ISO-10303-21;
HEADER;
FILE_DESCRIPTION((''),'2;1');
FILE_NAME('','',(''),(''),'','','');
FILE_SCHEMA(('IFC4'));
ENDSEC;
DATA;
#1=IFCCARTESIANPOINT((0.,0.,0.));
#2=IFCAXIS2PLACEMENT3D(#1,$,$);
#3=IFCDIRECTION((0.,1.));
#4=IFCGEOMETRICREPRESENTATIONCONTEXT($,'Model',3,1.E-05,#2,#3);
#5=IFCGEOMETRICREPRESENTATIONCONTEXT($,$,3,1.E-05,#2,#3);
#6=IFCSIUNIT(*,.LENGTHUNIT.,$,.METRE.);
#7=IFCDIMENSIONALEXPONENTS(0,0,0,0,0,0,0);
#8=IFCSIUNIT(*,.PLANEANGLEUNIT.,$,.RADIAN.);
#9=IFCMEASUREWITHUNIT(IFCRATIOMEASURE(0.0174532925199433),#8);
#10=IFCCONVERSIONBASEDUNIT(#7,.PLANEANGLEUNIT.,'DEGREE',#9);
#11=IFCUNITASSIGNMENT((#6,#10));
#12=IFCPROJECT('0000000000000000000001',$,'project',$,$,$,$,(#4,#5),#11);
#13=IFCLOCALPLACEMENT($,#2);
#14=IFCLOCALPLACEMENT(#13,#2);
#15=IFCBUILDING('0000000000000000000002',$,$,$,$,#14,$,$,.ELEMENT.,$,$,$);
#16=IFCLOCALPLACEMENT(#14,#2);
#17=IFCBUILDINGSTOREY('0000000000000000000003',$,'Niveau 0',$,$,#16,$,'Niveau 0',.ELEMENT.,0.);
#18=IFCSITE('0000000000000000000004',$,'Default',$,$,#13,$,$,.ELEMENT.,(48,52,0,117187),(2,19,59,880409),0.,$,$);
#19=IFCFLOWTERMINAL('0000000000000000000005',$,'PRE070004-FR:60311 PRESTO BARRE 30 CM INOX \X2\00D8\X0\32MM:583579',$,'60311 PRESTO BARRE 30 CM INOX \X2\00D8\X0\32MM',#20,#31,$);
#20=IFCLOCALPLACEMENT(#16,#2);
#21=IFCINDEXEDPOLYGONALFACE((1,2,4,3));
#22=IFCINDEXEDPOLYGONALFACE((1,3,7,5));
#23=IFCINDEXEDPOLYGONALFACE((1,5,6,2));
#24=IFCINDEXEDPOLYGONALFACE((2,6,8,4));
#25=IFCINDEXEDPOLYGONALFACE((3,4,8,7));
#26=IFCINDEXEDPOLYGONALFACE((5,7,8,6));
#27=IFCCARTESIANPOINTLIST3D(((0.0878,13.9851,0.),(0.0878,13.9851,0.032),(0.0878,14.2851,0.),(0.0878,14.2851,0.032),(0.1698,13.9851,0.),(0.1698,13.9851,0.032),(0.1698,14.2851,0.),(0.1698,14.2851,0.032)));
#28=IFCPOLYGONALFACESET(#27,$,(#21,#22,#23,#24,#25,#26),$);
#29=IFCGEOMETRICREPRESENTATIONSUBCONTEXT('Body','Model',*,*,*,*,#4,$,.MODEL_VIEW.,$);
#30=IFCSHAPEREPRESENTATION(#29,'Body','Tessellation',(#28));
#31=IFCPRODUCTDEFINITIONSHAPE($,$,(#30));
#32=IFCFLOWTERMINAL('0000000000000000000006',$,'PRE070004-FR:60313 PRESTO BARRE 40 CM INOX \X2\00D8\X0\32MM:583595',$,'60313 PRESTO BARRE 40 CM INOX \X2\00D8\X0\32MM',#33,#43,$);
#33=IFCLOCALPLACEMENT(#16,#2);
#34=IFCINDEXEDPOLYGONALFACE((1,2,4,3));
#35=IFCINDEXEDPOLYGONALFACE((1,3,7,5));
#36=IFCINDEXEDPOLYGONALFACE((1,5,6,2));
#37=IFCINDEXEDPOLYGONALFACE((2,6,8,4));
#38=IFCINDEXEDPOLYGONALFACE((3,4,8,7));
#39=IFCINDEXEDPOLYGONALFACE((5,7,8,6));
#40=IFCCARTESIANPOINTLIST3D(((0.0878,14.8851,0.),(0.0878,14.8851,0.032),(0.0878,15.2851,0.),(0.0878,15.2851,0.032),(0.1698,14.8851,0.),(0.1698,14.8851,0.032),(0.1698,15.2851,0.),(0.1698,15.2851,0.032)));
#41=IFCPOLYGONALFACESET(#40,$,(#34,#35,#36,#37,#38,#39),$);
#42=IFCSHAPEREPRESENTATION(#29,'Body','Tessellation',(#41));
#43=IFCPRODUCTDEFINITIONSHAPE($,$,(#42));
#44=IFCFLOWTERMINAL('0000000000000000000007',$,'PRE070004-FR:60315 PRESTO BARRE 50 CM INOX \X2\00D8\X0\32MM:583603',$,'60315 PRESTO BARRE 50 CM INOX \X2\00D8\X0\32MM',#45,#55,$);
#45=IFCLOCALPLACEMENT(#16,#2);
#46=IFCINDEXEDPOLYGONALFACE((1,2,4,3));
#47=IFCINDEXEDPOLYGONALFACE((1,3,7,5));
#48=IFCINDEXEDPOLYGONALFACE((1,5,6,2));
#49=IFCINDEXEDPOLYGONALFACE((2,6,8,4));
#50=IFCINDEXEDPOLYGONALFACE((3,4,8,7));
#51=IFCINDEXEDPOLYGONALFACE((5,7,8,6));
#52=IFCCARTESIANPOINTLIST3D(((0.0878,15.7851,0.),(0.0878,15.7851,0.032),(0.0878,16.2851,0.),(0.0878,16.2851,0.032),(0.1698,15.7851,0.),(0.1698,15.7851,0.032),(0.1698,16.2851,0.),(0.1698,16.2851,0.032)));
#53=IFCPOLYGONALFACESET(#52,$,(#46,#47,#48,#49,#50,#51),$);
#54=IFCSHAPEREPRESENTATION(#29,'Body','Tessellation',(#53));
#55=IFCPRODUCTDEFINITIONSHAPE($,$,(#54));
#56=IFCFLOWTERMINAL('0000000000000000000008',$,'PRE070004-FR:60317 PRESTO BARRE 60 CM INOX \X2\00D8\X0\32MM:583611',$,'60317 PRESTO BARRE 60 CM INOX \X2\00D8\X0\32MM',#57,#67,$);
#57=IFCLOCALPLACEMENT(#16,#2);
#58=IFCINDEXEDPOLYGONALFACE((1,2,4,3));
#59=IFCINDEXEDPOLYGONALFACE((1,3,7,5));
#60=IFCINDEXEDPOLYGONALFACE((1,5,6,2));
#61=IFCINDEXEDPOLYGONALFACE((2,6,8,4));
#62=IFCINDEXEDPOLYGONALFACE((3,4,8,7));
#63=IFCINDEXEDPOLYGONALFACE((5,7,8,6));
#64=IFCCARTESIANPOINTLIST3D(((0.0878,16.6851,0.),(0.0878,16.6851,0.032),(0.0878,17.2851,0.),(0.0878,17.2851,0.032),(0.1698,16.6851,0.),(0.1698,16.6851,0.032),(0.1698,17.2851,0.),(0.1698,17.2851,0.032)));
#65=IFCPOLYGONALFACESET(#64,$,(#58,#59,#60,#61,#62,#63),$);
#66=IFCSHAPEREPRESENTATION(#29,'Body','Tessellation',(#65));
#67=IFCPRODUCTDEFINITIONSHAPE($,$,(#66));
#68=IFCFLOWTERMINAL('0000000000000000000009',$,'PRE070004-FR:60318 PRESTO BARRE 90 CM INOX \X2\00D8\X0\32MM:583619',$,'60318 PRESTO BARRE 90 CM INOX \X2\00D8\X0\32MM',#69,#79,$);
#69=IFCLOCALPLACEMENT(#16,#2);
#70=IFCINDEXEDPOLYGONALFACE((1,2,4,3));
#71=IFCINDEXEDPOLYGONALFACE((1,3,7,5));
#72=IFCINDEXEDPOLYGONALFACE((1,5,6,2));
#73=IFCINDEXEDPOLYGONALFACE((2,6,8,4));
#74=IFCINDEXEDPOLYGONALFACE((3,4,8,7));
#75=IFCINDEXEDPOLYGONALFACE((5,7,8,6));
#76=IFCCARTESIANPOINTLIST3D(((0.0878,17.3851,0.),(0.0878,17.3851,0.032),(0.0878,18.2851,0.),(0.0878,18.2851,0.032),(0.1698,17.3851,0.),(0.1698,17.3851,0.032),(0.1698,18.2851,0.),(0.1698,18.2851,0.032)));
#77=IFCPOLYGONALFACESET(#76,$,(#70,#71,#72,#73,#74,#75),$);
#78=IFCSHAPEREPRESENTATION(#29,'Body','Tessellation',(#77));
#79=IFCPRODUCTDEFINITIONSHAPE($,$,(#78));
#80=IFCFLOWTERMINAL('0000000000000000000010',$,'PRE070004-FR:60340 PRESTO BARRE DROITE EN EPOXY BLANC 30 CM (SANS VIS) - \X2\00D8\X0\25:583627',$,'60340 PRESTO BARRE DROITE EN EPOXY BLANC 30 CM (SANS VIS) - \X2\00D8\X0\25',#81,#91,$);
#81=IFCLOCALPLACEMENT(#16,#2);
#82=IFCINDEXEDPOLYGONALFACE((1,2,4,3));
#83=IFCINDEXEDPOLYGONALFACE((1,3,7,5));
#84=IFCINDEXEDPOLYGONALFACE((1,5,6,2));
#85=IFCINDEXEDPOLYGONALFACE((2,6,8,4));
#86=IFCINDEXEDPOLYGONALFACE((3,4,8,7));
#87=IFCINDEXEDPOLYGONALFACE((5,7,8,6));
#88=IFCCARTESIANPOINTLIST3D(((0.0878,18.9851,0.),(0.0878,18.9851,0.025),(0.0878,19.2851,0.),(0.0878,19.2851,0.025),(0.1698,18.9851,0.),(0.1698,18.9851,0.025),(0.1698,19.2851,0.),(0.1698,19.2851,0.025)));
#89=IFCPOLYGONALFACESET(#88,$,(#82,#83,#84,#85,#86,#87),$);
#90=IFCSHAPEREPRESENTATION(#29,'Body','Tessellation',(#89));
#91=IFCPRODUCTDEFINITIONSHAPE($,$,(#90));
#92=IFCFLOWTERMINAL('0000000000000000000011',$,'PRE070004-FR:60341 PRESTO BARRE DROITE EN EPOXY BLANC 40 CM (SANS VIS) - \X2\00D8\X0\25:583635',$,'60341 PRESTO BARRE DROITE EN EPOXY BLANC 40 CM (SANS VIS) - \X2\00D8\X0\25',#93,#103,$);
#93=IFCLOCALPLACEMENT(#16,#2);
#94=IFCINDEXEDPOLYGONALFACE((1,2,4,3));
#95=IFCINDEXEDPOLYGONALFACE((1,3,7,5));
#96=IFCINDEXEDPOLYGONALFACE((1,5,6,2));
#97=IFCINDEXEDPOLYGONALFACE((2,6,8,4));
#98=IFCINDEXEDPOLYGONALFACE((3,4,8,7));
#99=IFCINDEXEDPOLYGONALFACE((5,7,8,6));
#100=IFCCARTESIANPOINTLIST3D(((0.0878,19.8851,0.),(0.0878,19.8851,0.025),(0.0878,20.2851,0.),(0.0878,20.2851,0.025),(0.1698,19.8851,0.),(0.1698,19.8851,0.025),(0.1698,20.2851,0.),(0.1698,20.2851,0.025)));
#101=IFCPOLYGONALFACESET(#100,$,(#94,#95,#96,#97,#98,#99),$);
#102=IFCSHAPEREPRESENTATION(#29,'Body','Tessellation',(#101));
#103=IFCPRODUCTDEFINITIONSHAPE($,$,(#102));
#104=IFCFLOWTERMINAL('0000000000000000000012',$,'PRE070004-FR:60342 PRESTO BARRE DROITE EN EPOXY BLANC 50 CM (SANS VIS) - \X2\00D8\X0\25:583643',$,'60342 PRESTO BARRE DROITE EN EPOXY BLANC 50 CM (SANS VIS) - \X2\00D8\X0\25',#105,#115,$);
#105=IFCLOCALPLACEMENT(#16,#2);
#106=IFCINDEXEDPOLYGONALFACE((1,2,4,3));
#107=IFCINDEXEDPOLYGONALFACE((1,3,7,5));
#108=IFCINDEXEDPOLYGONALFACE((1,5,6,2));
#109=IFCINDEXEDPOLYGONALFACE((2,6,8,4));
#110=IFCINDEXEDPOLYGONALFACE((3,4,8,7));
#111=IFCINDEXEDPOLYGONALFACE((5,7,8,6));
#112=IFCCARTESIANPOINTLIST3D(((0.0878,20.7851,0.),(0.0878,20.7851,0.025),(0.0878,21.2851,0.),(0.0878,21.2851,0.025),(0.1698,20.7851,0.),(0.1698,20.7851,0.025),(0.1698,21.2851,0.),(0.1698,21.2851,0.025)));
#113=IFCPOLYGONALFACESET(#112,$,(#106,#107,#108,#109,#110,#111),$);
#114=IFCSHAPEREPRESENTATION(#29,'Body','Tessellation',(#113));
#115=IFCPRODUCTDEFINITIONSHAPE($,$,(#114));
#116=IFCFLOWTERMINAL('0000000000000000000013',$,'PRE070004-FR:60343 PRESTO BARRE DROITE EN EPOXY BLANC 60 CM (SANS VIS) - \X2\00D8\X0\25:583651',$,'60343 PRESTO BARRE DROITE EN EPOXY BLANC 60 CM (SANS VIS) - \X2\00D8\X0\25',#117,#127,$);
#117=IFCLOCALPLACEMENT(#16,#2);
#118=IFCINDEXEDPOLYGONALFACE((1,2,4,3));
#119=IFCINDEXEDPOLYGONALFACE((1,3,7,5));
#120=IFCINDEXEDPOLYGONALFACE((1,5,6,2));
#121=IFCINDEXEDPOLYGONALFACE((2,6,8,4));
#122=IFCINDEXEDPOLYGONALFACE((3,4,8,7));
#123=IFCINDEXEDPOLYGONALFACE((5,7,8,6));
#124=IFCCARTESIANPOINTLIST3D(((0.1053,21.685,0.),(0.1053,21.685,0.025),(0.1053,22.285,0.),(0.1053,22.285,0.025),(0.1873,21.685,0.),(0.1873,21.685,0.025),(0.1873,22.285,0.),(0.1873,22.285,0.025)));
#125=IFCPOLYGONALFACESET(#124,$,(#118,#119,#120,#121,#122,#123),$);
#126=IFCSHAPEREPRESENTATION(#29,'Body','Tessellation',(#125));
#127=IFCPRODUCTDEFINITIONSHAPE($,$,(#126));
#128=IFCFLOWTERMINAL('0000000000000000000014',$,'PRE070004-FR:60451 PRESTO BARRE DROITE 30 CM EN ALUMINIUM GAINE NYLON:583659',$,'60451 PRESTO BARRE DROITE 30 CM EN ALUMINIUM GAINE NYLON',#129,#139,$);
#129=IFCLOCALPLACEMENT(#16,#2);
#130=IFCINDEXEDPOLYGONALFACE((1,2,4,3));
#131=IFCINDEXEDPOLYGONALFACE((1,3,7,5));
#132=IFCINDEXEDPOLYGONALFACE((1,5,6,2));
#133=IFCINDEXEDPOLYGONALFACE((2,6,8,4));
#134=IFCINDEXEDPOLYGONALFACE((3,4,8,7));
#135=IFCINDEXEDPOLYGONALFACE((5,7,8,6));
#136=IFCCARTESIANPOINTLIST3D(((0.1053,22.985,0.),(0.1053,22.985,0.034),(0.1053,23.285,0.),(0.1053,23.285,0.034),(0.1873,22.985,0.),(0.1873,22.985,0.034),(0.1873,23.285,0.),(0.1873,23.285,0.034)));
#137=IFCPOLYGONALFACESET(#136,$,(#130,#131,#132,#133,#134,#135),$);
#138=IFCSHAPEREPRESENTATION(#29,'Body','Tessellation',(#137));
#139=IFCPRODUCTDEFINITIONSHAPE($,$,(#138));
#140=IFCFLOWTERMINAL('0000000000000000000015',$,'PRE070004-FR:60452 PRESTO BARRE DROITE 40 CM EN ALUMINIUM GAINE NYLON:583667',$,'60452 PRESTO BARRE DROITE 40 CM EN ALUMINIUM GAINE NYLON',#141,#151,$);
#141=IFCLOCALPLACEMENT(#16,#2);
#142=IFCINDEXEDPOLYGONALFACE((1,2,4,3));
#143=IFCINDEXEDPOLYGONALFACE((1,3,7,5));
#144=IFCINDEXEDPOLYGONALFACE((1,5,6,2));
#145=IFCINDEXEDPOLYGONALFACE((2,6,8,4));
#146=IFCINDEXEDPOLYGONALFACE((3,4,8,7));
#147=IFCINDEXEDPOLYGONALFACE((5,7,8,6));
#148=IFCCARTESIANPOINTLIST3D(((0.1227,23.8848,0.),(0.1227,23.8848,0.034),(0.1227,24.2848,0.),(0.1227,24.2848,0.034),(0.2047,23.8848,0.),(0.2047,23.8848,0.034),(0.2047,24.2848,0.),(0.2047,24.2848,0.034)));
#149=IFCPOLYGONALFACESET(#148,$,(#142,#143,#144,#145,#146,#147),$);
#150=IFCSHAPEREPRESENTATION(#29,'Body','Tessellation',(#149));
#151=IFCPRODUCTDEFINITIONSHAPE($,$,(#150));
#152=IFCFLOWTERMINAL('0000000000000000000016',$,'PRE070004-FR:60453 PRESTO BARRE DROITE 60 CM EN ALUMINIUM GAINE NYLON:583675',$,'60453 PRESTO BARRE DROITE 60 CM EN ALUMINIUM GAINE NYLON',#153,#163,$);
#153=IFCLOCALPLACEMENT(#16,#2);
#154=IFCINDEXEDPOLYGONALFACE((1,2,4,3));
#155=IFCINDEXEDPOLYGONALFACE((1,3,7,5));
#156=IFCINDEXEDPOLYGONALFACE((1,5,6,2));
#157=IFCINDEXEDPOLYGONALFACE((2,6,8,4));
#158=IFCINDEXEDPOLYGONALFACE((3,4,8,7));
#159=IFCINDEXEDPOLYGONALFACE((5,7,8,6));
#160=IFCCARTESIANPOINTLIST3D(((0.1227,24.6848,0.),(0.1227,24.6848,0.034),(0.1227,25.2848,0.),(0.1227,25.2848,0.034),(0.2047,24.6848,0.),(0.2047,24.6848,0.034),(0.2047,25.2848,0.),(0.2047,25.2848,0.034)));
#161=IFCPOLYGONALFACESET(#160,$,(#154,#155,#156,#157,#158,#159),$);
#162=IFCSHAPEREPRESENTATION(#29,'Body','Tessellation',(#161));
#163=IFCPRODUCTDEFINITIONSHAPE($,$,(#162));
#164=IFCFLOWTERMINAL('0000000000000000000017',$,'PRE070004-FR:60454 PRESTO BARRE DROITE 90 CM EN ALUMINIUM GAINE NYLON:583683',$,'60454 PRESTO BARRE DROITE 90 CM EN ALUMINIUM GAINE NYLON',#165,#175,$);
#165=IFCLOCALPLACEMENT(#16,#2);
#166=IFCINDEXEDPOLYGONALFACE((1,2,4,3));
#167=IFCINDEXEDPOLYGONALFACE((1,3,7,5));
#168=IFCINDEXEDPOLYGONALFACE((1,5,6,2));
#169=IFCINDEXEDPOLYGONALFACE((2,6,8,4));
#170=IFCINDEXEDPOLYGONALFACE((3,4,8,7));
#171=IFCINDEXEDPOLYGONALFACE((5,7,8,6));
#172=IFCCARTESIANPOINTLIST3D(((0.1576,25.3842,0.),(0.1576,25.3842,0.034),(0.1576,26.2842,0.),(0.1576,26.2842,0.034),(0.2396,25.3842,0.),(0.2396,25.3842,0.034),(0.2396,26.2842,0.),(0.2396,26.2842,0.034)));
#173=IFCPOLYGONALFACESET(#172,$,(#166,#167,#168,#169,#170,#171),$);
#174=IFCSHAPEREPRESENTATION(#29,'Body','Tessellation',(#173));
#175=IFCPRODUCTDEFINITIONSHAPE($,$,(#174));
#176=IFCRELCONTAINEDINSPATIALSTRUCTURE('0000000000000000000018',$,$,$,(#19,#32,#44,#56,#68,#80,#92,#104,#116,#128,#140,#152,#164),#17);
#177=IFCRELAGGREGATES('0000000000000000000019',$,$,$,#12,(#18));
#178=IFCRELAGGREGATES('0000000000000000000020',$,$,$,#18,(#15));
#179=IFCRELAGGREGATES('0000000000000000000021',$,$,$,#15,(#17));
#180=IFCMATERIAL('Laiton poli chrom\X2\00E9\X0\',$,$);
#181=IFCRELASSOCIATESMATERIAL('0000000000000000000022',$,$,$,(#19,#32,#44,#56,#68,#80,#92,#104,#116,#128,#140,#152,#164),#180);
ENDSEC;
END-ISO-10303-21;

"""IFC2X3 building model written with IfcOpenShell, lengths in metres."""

from ifc_helpers import new_model, entity, si_unit, converted_unit, direction, frame, origin, origin_2d_with_axis, place, context, subcontext, project, spatial, rectangle, extrude, source, transform, mapped, material, element, save


model = new_model("IFC2X3")

# Units and contexts
model_context = context("Model", 3, precision=1e-05, world=origin(), true_north=direction((0.0, 1.0)))
context_of_model = context(None, 3, precision=1e-05, world=origin(), true_north=direction((0.0, 1.0)))
body_context = subcontext(model_context, "Body", "Model", "MODEL_VIEW")
ifc_project = project(units=[si_unit("LENGTHUNIT", "METRE"), converted_unit("PLANEANGLEUNIT", "DEGREE", entity("IfcRatioMeasure", 0.0174532925199433), si_unit("PLANEANGLEUNIT", "RADIAN"), dimensions=[0, 0, 0, 0, 0, 0, 0])], contexts=[model_context, context_of_model])

# Site, building, storey
site_placement = place(None, origin())
site = spatial("IfcSite", under=ifc_project, at=site_placement, Name="Default", CompositionType="ELEMENT", RefLatitude=(48, 52, 0, 117187), RefLongitude=(2, 19, 59, 880409), RefElevation=0.0)
building_placement = place(site_placement, origin())
building = spatial("IfcBuilding", under=site, at=building_placement, CompositionType="ELEMENT")
storey_placement = place(building_placement, origin())
storey = spatial("IfcBuildingStorey", under=building, at=storey_placement, Name="Niveau 0", LongName="Niveau 0", CompositionType="ELEMENT", Elevation=0.0)

# Flow terminals
ifc_material = material(Name="Laiton poli chromé")
shared_shape_1 = source(origin(), body_context, "Body", "SweptSolid", [
    extrude(rectangle(XDim=0.082, YDim=0.3, at=origin_2d_with_axis()), frame((0.041, -0.15, 0.0), z_axis=(0.0, 0.0, 1.0), x_axis=(-1.0, 0.0, 0.0)), (0.0, 0.0, 1.0), 0.032),
])
flow_terminal_1_placement = place(storey_placement, frame((0.0878, 14.2851, 0.0)))
element("IfcFlowTerminal", 1, at=flow_terminal_1_placement, inside=storey, material=ifc_material, Name="PRE070004-FR:60311 PRESTO BARRE 30 CM INOX Ø32MM:583579", ObjectType="60311 PRESTO BARRE 30 CM INOX Ø32MM", context=body_context, shape_type="MappedRepresentation", body=[
    mapped(shared_shape_1, transform((0.0, 0.0, 0.0), scale=1.0)),
])
shared_shape_2 = source(origin(), body_context, "Body", "SweptSolid", [
    extrude(rectangle(XDim=0.082, YDim=0.4, at=origin_2d_with_axis()), frame((0.041, -0.2, 0.0), z_axis=(0.0, 0.0, 1.0), x_axis=(-1.0, 0.0, 0.0)), (0.0, 0.0, 1.0), 0.032),
])
flow_terminal_2_placement = place(storey_placement, frame((0.0878, 15.2851, 0.0)))
element("IfcFlowTerminal", 2, at=flow_terminal_2_placement, inside=storey, material=ifc_material, Name="PRE070004-FR:60313 PRESTO BARRE 40 CM INOX Ø32MM:583595", ObjectType="60313 PRESTO BARRE 40 CM INOX Ø32MM", context=body_context, shape_type="MappedRepresentation", body=[
    mapped(shared_shape_2, transform((0.0, 0.0, 0.0), scale=1.0)),
])
shared_shape_3 = source(origin(), body_context, "Body", "SweptSolid", [
    extrude(rectangle(XDim=0.082, YDim=0.5, at=origin_2d_with_axis()), frame((0.041, -0.25, 0.0), z_axis=(0.0, 0.0, 1.0), x_axis=(-1.0, 0.0, 0.0)), (0.0, 0.0, 1.0), 0.032),
])
flow_terminal_3_placement = place(storey_placement, frame((0.0878, 16.2851, 0.0)))
element("IfcFlowTerminal", 3, at=flow_terminal_3_placement, inside=storey, material=ifc_material, Name="PRE070004-FR:60315 PRESTO BARRE 50 CM INOX Ø32MM:583603", ObjectType="60315 PRESTO BARRE 50 CM INOX Ø32MM", context=body_context, shape_type="MappedRepresentation", body=[
    mapped(shared_shape_3, transform((0.0, 0.0, 0.0), scale=1.0)),
])
shared_shape_4 = source(origin(), body_context, "Body", "SweptSolid", [
    extrude(rectangle(XDim=0.082, YDim=0.6, at=origin_2d_with_axis()), frame((0.041, -0.3, 0.0), z_axis=(0.0, 0.0, 1.0), x_axis=(-1.0, 0.0, 0.0)), (0.0, 0.0, 1.0), 0.032),
])
flow_terminal_4_placement = place(storey_placement, frame((0.0878, 17.2851, 0.0)))
element("IfcFlowTerminal", 4, at=flow_terminal_4_placement, inside=storey, material=ifc_material, Name="PRE070004-FR:60317 PRESTO BARRE 60 CM INOX Ø32MM:583611", ObjectType="60317 PRESTO BARRE 60 CM INOX Ø32MM", context=body_context, shape_type="MappedRepresentation", body=[
    mapped(shared_shape_4, transform((0.0, 0.0, 0.0), scale=1.0)),
])
shared_shape_5 = source(origin(), body_context, "Body", "SweptSolid", [
    extrude(rectangle(XDim=0.082, YDim=0.9, at=origin_2d_with_axis()), frame((0.041, -0.45, 0.0), z_axis=(0.0, 0.0, 1.0), x_axis=(-1.0, 0.0, 0.0)), (0.0, 0.0, 1.0), 0.032),
])
flow_terminal_5_placement = place(storey_placement, frame((0.0878, 18.2851, 0.0)))
element("IfcFlowTerminal", 5, at=flow_terminal_5_placement, inside=storey, material=ifc_material, Name="PRE070004-FR:60318 PRESTO BARRE 90 CM INOX Ø32MM:583619", ObjectType="60318 PRESTO BARRE 90 CM INOX Ø32MM", context=body_context, shape_type="MappedRepresentation", body=[
    mapped(shared_shape_5, transform((0.0, 0.0, 0.0), scale=1.0)),
])
shared_shape_6 = source(origin(), body_context, "Body", "SweptSolid", [
    extrude(rectangle(XDim=0.082, YDim=0.3, at=origin_2d_with_axis()), frame((0.041, -0.15, 0.0), z_axis=(0.0, 0.0, 1.0), x_axis=(-1.0, 0.0, 0.0)), (0.0, 0.0, 1.0), 0.025),
])
flow_terminal_6_placement = place(storey_placement, frame((0.0878, 19.2851, 0.0)))
element("IfcFlowTerminal", 6, at=flow_terminal_6_placement, inside=storey, material=ifc_material, Name="PRE070004-FR:60340 PRESTO BARRE DROITE EN EPOXY BLANC 30 CM (SANS VIS) - Ø25:583627", ObjectType="60340 PRESTO BARRE DROITE EN EPOXY BLANC 30 CM (SANS VIS) - Ø25", context=body_context, shape_type="MappedRepresentation", body=[
    mapped(shared_shape_6, transform((0.0, 0.0, 0.0), scale=1.0)),
])
shared_shape_7 = source(origin(), body_context, "Body", "SweptSolid", [
    extrude(rectangle(XDim=0.082, YDim=0.4, at=origin_2d_with_axis()), frame((0.041, -0.2, 0.0), z_axis=(0.0, 0.0, 1.0), x_axis=(-1.0, 0.0, 0.0)), (0.0, 0.0, 1.0), 0.025),
])
flow_terminal_7_placement = place(storey_placement, frame((0.0878, 20.2851, 0.0)))
element("IfcFlowTerminal", 7, at=flow_terminal_7_placement, inside=storey, material=ifc_material, Name="PRE070004-FR:60341 PRESTO BARRE DROITE EN EPOXY BLANC 40 CM (SANS VIS) - Ø25:583635", ObjectType="60341 PRESTO BARRE DROITE EN EPOXY BLANC 40 CM (SANS VIS) - Ø25", context=body_context, shape_type="MappedRepresentation", body=[
    mapped(shared_shape_7, transform((0.0, 0.0, 0.0), scale=1.0)),
])
shared_shape_8 = source(origin(), body_context, "Body", "SweptSolid", [
    extrude(rectangle(XDim=0.082, YDim=0.5, at=origin_2d_with_axis()), frame((0.041, -0.25, 0.0), z_axis=(0.0, 0.0, 1.0), x_axis=(-1.0, 0.0, 0.0)), (0.0, 0.0, 1.0), 0.025),
])
flow_terminal_8_placement = place(storey_placement, frame((0.0878, 21.2851, 0.0)))
element("IfcFlowTerminal", 8, at=flow_terminal_8_placement, inside=storey, material=ifc_material, Name="PRE070004-FR:60342 PRESTO BARRE DROITE EN EPOXY BLANC 50 CM (SANS VIS) - Ø25:583643", ObjectType="60342 PRESTO BARRE DROITE EN EPOXY BLANC 50 CM (SANS VIS) - Ø25", context=body_context, shape_type="MappedRepresentation", body=[
    mapped(shared_shape_8, transform((0.0, 0.0, 0.0), scale=1.0)),
])
shared_shape_9 = source(origin(), body_context, "Body", "SweptSolid", [
    extrude(rectangle(XDim=0.082, YDim=0.6, at=origin_2d_with_axis()), frame((0.041, -0.3, 0.0), z_axis=(0.0, 0.0, 1.0), x_axis=(-1.0, 0.0, 0.0)), (0.0, 0.0, 1.0), 0.025),
])
flow_terminal_9_placement = place(storey_placement, frame((0.1053, 22.285, 0.0)))
element("IfcFlowTerminal", 9, at=flow_terminal_9_placement, inside=storey, material=ifc_material, Name="PRE070004-FR:60343 PRESTO BARRE DROITE EN EPOXY BLANC 60 CM (SANS VIS) - Ø25:583651", ObjectType="60343 PRESTO BARRE DROITE EN EPOXY BLANC 60 CM (SANS VIS) - Ø25", context=body_context, shape_type="MappedRepresentation", body=[
    mapped(shared_shape_9, transform((0.0, 0.0, 0.0), scale=1.0)),
])
shared_shape_10 = source(origin(), body_context, "Body", "SweptSolid", [
    extrude(rectangle(XDim=0.082, YDim=0.3, at=origin_2d_with_axis()), frame((0.041, -0.15, 0.0), z_axis=(0.0, 0.0, 1.0), x_axis=(-1.0, 0.0, 0.0)), (0.0, 0.0, 1.0), 0.034),
])
flow_terminal_10_placement = place(storey_placement, frame((0.1053, 23.285, 0.0)))
element("IfcFlowTerminal", 10, at=flow_terminal_10_placement, inside=storey, material=ifc_material, Name="PRE070004-FR:60451 PRESTO BARRE DROITE 30 CM EN ALUMINIUM GAINE NYLON:583659", ObjectType="60451 PRESTO BARRE DROITE 30 CM EN ALUMINIUM GAINE NYLON", context=body_context, shape_type="MappedRepresentation", body=[
    mapped(shared_shape_10, transform((0.0, 0.0, 0.0), scale=1.0)),
])
shared_shape_11 = source(origin(), body_context, "Body", "SweptSolid", [
    extrude(rectangle(XDim=0.082, YDim=0.4, at=origin_2d_with_axis()), frame((0.041, -0.2, 0.0), z_axis=(0.0, 0.0, 1.0), x_axis=(-1.0, 0.0, 0.0)), (0.0, 0.0, 1.0), 0.034),
])
flow_terminal_11_placement = place(storey_placement, frame((0.1227, 24.2848, 0.0)))
element("IfcFlowTerminal", 11, at=flow_terminal_11_placement, inside=storey, material=ifc_material, Name="PRE070004-FR:60452 PRESTO BARRE DROITE 40 CM EN ALUMINIUM GAINE NYLON:583667", ObjectType="60452 PRESTO BARRE DROITE 40 CM EN ALUMINIUM GAINE NYLON", context=body_context, shape_type="MappedRepresentation", body=[
    mapped(shared_shape_11, transform((0.0, 0.0, 0.0), scale=1.0)),
])
shared_shape_12 = source(origin(), body_context, "Body", "SweptSolid", [
    extrude(rectangle(XDim=0.082, YDim=0.6, at=origin_2d_with_axis()), frame((0.041, -0.3, 0.0), z_axis=(0.0, 0.0, 1.0), x_axis=(-1.0, 0.0, 0.0)), (0.0, 0.0, 1.0), 0.034),
])
flow_terminal_12_placement = place(storey_placement, frame((0.1227, 25.2848, 0.0)))
element("IfcFlowTerminal", 12, at=flow_terminal_12_placement, inside=storey, material=ifc_material, Name="PRE070004-FR:60453 PRESTO BARRE DROITE 60 CM EN ALUMINIUM GAINE NYLON:583675", ObjectType="60453 PRESTO BARRE DROITE 60 CM EN ALUMINIUM GAINE NYLON", context=body_context, shape_type="MappedRepresentation", body=[
    mapped(shared_shape_12, transform((0.0, 0.0, 0.0), scale=1.0)),
])
shared_shape_13 = source(origin(), body_context, "Body", "SweptSolid", [
    extrude(rectangle(XDim=0.082, YDim=0.9, at=origin_2d_with_axis()), frame((0.041, -0.45, 0.0), z_axis=(0.0, 0.0, 1.0), x_axis=(-1.0, 0.0, 0.0)), (0.0, 0.0, 1.0), 0.034),
])
flow_terminal_13_placement = place(storey_placement, frame((0.1576, 26.2842, 0.0)))
element("IfcFlowTerminal", 13, at=flow_terminal_13_placement, inside=storey, material=ifc_material, Name="PRE070004-FR:60454 PRESTO BARRE DROITE 90 CM EN ALUMINIUM GAINE NYLON:583683", ObjectType="60454 PRESTO BARRE DROITE 90 CM EN ALUMINIUM GAINE NYLON", context=body_context, shape_type="MappedRepresentation", body=[
    mapped(shared_shape_13, transform((0.0, 0.0, 0.0), scale=1.0)),
])

save(model, "model.ifc")
